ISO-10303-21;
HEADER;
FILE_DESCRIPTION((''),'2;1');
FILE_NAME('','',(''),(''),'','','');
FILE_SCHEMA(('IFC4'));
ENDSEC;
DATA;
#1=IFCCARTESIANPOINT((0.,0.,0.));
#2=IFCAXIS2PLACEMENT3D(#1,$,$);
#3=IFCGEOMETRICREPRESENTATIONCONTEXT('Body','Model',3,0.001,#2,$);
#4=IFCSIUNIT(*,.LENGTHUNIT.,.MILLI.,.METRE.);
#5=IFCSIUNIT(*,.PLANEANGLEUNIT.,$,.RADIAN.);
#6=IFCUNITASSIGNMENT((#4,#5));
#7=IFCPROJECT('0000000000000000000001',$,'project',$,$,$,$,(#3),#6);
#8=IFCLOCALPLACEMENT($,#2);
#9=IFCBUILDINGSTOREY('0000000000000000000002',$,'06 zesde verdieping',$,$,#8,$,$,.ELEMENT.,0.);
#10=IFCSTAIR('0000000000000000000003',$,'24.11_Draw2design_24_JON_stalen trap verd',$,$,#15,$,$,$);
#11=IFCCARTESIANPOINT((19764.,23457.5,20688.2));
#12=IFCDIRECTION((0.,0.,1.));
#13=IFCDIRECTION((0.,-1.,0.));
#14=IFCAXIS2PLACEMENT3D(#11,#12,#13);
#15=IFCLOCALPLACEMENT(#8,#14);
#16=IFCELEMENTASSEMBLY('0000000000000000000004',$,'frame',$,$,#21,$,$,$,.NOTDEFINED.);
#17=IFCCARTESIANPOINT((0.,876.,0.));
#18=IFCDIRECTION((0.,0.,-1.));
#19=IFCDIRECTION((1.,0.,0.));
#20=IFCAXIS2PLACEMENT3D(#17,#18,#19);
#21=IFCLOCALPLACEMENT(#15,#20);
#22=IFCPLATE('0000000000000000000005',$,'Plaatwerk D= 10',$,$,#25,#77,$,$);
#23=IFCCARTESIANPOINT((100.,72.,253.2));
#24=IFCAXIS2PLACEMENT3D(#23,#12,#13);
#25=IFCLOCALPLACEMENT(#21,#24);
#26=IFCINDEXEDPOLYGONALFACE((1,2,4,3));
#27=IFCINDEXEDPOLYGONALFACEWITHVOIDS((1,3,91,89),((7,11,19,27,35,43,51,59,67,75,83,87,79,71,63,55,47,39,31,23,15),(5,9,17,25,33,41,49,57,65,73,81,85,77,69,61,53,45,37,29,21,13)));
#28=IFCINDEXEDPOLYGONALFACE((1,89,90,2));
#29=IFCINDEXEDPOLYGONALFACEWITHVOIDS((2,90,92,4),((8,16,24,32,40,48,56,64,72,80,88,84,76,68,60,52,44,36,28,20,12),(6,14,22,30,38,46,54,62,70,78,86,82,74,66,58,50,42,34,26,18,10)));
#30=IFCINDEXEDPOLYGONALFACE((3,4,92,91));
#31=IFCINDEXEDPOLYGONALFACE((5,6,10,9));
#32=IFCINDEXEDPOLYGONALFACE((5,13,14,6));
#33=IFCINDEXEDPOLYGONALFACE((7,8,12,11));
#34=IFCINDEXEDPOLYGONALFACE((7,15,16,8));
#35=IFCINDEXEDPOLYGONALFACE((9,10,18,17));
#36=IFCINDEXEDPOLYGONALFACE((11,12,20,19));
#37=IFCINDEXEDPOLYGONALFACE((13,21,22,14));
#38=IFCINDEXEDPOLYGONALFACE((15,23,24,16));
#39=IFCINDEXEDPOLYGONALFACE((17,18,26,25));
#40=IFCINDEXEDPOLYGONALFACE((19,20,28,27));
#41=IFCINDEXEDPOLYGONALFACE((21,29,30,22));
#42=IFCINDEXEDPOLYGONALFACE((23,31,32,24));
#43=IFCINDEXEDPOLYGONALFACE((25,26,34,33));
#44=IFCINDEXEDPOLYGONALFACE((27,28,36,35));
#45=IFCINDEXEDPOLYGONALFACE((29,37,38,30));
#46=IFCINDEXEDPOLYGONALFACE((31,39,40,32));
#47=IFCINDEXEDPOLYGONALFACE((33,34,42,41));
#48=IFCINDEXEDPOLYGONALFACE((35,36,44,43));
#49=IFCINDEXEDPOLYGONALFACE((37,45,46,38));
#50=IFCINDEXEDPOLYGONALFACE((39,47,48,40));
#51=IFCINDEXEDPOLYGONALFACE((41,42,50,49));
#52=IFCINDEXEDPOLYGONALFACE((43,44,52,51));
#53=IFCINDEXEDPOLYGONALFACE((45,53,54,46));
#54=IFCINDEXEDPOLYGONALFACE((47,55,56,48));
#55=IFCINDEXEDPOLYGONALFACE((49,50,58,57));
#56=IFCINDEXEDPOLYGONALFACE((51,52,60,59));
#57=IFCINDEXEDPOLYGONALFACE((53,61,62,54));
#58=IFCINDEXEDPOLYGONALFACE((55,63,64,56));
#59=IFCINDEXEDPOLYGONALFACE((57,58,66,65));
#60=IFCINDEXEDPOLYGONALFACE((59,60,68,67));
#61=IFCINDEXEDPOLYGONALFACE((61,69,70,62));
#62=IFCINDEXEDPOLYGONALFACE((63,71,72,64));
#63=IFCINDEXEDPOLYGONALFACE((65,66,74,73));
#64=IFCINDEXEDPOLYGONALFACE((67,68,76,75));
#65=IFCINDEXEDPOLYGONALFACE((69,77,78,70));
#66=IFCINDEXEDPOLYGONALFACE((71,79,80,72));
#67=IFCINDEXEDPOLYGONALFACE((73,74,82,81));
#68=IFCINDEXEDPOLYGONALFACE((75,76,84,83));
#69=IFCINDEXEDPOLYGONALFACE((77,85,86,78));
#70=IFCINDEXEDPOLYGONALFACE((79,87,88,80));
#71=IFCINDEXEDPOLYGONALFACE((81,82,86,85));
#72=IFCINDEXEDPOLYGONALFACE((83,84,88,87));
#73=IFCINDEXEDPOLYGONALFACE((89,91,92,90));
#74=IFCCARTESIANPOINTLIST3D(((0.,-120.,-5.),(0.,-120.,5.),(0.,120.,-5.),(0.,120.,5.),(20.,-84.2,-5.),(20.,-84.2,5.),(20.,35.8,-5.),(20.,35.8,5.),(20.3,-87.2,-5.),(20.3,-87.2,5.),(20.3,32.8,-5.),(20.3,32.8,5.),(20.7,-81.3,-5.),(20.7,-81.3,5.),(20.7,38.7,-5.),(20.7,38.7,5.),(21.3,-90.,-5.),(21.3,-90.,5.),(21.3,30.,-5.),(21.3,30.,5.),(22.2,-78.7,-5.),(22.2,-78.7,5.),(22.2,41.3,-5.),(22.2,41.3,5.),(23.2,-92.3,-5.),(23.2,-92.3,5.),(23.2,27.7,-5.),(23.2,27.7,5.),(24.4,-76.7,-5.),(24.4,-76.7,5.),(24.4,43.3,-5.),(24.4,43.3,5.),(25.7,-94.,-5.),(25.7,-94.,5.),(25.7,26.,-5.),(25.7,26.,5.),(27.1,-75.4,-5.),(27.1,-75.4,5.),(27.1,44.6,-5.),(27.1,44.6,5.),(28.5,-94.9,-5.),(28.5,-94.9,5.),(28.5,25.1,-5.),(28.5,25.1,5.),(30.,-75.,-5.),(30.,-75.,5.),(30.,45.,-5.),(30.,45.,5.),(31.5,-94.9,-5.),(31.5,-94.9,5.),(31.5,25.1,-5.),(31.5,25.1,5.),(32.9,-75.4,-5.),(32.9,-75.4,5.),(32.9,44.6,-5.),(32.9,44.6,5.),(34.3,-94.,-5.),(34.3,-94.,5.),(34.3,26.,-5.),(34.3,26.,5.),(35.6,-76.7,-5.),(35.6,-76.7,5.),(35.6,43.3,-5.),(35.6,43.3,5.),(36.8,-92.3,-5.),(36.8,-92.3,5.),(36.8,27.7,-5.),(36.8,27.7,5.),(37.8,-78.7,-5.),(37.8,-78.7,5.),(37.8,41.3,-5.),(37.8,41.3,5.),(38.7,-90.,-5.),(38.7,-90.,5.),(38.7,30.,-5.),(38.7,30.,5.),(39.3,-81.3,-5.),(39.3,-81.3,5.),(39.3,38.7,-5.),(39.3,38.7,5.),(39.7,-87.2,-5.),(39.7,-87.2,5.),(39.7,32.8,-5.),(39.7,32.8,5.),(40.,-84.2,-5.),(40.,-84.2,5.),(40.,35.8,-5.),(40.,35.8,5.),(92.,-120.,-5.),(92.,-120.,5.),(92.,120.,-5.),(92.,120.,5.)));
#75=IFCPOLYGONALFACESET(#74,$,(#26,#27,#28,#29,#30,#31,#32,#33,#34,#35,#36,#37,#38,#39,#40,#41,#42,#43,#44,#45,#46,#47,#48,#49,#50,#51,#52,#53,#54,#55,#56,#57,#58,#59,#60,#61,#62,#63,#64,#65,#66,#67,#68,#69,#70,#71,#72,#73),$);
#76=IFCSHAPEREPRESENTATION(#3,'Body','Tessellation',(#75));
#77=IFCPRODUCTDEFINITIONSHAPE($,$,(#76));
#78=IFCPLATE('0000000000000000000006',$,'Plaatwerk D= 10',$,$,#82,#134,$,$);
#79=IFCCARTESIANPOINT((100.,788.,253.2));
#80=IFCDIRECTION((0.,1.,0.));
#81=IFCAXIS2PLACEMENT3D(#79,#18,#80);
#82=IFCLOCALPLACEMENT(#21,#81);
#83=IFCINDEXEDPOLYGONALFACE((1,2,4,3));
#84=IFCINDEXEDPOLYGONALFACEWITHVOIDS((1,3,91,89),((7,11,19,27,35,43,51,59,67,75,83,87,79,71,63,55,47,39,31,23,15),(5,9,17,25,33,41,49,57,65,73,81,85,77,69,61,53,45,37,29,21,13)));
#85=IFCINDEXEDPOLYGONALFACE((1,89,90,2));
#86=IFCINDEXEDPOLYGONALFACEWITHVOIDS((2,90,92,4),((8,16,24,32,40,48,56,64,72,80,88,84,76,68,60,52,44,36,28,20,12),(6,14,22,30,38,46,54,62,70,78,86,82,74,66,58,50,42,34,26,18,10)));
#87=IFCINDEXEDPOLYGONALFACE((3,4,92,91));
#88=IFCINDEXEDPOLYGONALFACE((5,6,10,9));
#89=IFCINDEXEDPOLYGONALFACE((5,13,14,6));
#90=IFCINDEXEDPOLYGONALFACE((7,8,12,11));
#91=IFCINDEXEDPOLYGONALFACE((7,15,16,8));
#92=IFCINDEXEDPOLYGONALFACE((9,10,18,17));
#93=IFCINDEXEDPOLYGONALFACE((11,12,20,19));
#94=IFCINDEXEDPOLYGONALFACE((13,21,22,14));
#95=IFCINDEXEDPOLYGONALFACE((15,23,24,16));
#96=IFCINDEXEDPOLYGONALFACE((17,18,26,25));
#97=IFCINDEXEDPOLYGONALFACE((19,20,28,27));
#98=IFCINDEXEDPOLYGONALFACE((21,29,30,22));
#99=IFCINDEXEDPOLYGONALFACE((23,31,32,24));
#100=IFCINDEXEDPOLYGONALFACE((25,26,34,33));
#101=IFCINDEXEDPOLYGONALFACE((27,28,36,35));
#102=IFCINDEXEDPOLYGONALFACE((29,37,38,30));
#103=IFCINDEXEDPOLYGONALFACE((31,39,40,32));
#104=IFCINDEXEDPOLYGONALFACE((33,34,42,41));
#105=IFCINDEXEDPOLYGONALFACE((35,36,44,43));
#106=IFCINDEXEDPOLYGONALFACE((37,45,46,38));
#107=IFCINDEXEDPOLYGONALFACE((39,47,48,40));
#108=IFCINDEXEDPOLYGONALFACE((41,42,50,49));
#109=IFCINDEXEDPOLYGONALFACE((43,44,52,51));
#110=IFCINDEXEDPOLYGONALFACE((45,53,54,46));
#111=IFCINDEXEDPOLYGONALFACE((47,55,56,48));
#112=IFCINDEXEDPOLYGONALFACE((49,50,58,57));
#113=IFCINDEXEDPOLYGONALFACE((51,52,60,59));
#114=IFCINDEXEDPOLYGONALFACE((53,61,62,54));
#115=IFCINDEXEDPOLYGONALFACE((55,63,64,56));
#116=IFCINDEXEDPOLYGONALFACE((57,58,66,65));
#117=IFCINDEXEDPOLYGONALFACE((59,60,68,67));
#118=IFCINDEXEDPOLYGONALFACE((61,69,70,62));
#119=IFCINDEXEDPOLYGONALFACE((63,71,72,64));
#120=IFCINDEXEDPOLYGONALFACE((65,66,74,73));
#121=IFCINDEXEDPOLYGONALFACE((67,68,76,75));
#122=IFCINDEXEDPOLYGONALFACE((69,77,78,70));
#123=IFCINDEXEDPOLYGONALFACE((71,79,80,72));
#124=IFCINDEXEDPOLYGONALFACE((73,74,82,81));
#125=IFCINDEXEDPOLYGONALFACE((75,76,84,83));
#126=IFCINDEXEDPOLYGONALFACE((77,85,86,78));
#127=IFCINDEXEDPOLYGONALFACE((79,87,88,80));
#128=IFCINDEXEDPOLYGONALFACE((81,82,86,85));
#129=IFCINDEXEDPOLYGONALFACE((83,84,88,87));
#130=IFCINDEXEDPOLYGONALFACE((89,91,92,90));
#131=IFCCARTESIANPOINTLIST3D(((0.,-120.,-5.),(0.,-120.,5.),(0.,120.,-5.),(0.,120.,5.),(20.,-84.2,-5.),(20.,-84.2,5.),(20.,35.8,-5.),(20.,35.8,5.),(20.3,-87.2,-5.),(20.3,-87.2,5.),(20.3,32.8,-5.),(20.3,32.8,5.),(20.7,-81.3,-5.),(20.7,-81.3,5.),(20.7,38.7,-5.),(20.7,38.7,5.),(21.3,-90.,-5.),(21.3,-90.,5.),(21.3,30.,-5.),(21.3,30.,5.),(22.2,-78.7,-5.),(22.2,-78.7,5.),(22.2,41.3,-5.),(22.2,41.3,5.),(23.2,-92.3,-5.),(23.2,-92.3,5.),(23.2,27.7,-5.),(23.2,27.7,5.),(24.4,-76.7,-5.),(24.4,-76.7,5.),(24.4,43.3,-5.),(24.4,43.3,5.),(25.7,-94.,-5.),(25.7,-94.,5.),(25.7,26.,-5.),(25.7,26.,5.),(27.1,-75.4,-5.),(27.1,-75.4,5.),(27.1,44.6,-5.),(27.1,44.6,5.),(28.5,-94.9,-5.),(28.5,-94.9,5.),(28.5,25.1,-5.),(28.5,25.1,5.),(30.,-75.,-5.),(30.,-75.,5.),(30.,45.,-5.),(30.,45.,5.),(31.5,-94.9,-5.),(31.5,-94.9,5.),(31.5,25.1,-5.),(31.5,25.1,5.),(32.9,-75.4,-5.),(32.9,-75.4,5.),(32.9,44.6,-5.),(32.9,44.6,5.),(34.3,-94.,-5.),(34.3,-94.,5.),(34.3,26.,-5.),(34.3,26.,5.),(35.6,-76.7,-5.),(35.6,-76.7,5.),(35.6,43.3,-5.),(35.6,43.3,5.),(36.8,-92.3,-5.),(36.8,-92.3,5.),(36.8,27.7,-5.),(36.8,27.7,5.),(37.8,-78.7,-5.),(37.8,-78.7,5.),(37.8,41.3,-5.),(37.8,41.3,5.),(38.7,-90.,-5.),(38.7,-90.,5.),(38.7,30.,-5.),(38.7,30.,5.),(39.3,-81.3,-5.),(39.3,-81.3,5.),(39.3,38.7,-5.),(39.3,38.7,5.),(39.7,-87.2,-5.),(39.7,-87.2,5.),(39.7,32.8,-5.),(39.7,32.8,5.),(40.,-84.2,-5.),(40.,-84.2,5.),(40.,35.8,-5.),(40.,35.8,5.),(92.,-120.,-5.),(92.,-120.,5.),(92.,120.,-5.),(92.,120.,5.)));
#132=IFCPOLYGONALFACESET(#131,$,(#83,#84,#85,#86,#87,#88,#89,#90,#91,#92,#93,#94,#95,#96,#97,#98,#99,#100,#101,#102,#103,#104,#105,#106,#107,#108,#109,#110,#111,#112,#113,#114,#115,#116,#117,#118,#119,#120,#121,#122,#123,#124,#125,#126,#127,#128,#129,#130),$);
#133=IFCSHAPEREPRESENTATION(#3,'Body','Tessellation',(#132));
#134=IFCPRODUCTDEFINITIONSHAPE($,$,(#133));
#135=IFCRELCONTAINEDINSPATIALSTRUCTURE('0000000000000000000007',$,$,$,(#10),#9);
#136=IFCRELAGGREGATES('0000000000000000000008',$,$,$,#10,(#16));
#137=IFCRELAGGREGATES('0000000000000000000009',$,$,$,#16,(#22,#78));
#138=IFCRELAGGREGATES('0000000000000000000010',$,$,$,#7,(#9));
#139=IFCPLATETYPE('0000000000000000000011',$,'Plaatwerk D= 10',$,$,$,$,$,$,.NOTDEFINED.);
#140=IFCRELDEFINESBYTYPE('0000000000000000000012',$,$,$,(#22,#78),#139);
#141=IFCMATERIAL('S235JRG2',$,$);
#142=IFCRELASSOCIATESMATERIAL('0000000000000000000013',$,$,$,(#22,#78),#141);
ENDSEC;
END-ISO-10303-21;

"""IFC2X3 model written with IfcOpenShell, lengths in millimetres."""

from ifc_helpers import new_model, si_unit, frame, origin, origin_2d, place, context, project, spatial, rectangle, circle, extrude, source, transform, mapped, material, type_object, element, aggregate, save


model = new_model("IFC2X3")

# Units and contexts
model_context = context("Model", 3, precision=0.001, world=origin(), identifier="Body")
ifc_project = project(units=[si_unit("LENGTHUNIT", "METRE", prefix="MILLI"), si_unit("PLANEANGLEUNIT", "RADIAN")], contexts=[model_context])

# Storey
storey_placement = place(None, origin())
storey = spatial("IfcBuildingStorey", under=ifc_project, at=storey_placement, Name="06 zesde verdieping", CompositionType="ELEMENT", Elevation=0.0)

# Shared definitions
ifc_material_1 = material(Name="S235JRG2")

# Stair
stair_placement = place(storey_placement, frame((19764.0, 23457.5, 20688.2), z_axis=(0.0, 0.0, 1.0), x_axis=(0.0, -1.0, 0.0)))
stair = element("IfcStair", 1, at=stair_placement, inside=storey, Name="24.11_Draw2design_24_JON_stalen trap verd")

# Element assembly
assembly_placement = place(stair_placement, frame((0.0, 876.0, 0.0), z_axis=(0.0, 0.0, -1.0), x_axis=(1.0, 0.0, 0.0)))
assembly = element("IfcElementAssembly", 2, at=assembly_placement, Name="frame", PredefinedType="NOTDEFINED")
aggregate(stair, [assembly])

# Plates, openings
plate_type = type_object("IfcPlateType", Name="Plaatwerk D= 10")
shared_shape_1 = source(origin(), model_context, "Body", "SweptSolid", [
    extrude(rectangle(XDim=92.0, YDim=240.0, at=origin_2d()), frame((46.0, 0.0, -5.0)), (0.0, 0.0, 1.0), 10.0),
])
plate_1_placement = place(assembly_placement, frame((100.0, 72.0, 253.2), z_axis=(0.0, 0.0, 1.0), x_axis=(0.0, -1.0, 0.0)))
plate_1 = element("IfcPlate", 3, at=plate_1_placement, type_object=plate_type, material=ifc_material_1, Name="Plaatwerk D= 10", context=model_context, shape_type="MappedRepresentation", body=[
    mapped(shared_shape_1, transform((0.0, 0.0, 0.0), scale=1.0)),
])
opening_1_placement = place(plate_1_placement, frame((30.0, -85.0, 5.0), z_axis=(0.0, 0.0, -1.0), x_axis=(0.0, 1.0, 0.0)))
element("IfcOpeningElement", 4, at=opening_1_placement, cuts=plate_1, ObjectType="Opening", context=model_context, shape_type="SweptSolid", body=[
    extrude(circle(Radius=10.0, at=origin_2d()), origin(), (0.0, 0.0, 1.0), 10.0),
])
opening_2_placement = place(plate_1_placement, frame((30.0, 35.0, 5.0), z_axis=(0.0, 0.0, -1.0), x_axis=(0.0, 1.0, 0.0)))
element("IfcOpeningElement", 5, at=opening_2_placement, cuts=plate_1, ObjectType="Opening", context=model_context, shape_type="SweptSolid", body=[
    extrude(circle(Radius=10.0, at=origin_2d()), origin(), (0.0, 0.0, 1.0), 10.0),
])
plate_2_placement = place(assembly_placement, frame((100.0, 788.0, 253.2), z_axis=(0.0, 0.0, -1.0), x_axis=(0.0, 1.0, 0.0)))
plate_2 = element("IfcPlate", 6, at=plate_2_placement, type_object=plate_type, material=ifc_material_1, Name="Plaatwerk D= 10", context=model_context, shape_type="MappedRepresentation", body=[
    mapped(shared_shape_1, transform((0.0, 0.0, 0.0), scale=1.0)),
])
opening_3_placement = place(plate_2_placement, frame((30.0, -85.0, 5.0), z_axis=(0.0, 0.0, -1.0), x_axis=(0.0, 1.0, 0.0)))
element("IfcOpeningElement", 7, at=opening_3_placement, cuts=plate_2, ObjectType="Opening", context=model_context, shape_type="SweptSolid", body=[
    extrude(circle(Radius=10.0, at=origin_2d()), origin(), (0.0, 0.0, 1.0), 10.0),
])
opening_4_placement = place(plate_2_placement, frame((30.0, 35.0, 5.0), z_axis=(0.0, 0.0, -1.0), x_axis=(0.0, 1.0, 0.0)))
element("IfcOpeningElement", 8, at=opening_4_placement, cuts=plate_2, ObjectType="Opening", context=model_context, shape_type="SweptSolid", body=[
    extrude(circle(Radius=10.0, at=origin_2d()), origin(), (0.0, 0.0, 1.0), 10.0),
])
aggregate(assembly, [plate_1, plate_2])

save(model, "model.ifc")
